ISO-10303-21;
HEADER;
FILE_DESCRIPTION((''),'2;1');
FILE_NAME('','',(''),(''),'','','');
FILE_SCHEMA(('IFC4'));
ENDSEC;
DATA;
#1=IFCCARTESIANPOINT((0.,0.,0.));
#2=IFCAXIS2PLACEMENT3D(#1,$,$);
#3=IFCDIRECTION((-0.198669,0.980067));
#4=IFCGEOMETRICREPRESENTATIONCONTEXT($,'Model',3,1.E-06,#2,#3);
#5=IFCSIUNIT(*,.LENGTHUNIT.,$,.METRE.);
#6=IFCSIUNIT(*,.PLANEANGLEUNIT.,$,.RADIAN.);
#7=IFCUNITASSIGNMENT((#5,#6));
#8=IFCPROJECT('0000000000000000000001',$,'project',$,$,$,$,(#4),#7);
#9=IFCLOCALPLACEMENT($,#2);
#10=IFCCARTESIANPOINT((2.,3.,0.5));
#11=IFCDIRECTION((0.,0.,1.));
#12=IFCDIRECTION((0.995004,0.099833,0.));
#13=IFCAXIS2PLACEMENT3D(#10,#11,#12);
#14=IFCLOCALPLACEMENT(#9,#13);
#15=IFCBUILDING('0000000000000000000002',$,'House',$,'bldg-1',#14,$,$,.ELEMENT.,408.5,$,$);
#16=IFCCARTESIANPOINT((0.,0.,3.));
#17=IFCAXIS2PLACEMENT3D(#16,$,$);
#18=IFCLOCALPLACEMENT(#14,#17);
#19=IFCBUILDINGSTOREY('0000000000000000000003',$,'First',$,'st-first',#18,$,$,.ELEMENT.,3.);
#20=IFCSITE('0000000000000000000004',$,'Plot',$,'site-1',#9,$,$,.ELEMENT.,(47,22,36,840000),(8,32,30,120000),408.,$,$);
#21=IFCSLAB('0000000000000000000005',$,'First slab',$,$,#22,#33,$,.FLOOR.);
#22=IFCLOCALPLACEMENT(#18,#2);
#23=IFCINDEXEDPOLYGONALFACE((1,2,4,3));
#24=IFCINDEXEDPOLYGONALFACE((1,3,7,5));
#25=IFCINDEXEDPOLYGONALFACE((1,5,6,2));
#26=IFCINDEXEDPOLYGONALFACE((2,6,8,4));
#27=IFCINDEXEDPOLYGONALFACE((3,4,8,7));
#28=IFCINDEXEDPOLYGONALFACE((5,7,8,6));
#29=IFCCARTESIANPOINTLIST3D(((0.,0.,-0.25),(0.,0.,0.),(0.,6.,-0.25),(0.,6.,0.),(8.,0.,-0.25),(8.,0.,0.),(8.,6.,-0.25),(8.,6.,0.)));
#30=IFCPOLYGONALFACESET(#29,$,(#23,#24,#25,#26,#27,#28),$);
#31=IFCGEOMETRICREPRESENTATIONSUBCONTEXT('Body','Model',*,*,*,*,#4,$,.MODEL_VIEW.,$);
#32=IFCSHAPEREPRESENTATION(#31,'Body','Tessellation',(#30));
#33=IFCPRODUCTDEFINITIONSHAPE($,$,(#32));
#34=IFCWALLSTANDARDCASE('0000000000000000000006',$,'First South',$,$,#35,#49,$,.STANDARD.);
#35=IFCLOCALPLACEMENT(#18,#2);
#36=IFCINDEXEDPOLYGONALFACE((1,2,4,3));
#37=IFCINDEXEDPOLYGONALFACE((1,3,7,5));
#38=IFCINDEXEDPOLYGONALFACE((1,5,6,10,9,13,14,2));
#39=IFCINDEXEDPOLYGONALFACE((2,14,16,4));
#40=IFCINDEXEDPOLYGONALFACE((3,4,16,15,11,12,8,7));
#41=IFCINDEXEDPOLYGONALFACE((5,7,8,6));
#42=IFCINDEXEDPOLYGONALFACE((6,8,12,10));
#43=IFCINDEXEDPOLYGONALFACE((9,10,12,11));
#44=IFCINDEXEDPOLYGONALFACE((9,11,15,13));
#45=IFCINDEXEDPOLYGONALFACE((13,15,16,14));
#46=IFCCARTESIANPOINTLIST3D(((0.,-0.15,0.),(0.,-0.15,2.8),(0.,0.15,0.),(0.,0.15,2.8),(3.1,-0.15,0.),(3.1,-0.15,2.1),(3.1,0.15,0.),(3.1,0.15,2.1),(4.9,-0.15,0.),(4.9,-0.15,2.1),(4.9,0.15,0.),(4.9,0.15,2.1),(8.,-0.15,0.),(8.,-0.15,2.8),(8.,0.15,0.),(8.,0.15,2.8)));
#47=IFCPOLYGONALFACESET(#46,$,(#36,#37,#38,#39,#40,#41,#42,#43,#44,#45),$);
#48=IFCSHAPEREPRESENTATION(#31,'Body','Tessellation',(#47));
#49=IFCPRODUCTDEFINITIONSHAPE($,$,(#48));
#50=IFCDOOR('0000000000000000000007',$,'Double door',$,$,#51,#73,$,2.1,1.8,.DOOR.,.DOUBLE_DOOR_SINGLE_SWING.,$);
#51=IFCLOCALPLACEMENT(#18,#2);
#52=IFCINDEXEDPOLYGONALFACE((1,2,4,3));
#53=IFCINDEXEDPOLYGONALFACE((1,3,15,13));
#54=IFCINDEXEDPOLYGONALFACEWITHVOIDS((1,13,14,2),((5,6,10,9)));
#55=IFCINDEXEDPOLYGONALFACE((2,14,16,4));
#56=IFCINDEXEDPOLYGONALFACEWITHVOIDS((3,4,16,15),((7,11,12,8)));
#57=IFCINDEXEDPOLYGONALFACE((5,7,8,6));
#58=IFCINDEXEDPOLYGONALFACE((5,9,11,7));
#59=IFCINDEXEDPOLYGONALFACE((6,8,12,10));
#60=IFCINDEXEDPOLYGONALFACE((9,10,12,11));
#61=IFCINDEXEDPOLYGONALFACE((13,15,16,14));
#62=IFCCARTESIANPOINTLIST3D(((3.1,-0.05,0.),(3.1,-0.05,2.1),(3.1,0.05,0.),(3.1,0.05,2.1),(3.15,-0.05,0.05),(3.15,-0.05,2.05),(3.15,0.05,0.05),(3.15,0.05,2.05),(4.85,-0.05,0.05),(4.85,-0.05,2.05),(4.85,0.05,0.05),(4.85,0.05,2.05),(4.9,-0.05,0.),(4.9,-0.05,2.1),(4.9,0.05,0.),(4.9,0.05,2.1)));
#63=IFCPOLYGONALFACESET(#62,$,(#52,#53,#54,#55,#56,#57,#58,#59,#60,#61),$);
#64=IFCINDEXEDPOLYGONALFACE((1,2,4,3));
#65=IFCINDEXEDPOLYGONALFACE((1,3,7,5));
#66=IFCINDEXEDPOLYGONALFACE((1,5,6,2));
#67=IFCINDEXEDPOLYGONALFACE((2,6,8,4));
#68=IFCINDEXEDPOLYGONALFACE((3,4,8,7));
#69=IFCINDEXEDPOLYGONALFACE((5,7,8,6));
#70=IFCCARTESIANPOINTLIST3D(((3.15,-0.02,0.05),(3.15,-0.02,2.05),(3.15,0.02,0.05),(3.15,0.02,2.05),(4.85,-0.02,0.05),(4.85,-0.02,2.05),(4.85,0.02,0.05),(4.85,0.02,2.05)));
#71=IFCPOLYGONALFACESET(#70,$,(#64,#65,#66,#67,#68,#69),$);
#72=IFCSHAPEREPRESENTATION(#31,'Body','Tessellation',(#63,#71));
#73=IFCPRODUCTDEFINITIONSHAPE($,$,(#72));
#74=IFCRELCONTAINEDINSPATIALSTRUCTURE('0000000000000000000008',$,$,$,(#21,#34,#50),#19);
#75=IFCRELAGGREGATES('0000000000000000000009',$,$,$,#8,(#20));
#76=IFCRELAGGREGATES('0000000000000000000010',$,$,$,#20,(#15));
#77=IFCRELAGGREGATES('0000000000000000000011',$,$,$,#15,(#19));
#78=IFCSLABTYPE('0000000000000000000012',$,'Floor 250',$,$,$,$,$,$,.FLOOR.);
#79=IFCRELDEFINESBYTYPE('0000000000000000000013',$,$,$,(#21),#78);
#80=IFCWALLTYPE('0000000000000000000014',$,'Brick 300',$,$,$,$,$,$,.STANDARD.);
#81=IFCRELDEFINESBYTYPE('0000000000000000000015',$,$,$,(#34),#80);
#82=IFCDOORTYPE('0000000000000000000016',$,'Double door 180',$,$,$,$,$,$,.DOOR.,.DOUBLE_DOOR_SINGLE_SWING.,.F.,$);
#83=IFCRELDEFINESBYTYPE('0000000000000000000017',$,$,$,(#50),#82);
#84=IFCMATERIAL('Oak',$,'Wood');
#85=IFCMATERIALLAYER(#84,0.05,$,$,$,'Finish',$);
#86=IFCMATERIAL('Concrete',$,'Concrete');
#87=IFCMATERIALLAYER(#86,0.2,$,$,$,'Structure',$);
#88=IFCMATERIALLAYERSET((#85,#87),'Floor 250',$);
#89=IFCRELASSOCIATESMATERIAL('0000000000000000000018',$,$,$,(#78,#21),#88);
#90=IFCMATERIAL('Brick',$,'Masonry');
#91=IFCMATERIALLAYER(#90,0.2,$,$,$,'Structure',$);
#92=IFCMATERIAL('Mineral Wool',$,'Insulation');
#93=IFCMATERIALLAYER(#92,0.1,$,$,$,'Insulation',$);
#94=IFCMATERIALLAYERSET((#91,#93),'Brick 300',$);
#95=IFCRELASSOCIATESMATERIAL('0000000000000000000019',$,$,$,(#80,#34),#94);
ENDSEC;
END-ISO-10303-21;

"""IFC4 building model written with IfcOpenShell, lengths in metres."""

from ifc_helpers import new_model, si_unit, direction, frame, frame_2d, origin, origin_with_axes, origin_2d, place, context, subcontext, project, spatial, polyline, rectangle, outline, extrude, material, layer, layer_set, layer_usage, type_object, element, fill, save


model = new_model("IFC4")

# Units and contexts
model_context = context("Model", 3, precision=1e-06, world=origin(), true_north=direction((-0.198669, 0.980067)))
body_context = subcontext(model_context, "Body", "Model", "MODEL_VIEW")
ifc_project = project(units=[si_unit("LENGTHUNIT", "METRE"), si_unit("PLANEANGLEUNIT", "RADIAN")], contexts=[model_context])

# Site, building, storey
site_placement = place(None, origin())
site = spatial("IfcSite", under=ifc_project, at=site_placement, Name="Plot", ObjectType="site-1", CompositionType="ELEMENT", RefLatitude=(47, 22, 36, 840000), RefLongitude=(8, 32, 30, 120000), RefElevation=408.0)
building_placement = place(site_placement, frame((2.0, 3.0, 0.5), z_axis=(0.0, 0.0, 1.0), x_axis=(0.995004, 0.099833, 0.0)))
building = spatial("IfcBuilding", under=site, at=building_placement, Name="House", ObjectType="bldg-1", CompositionType="ELEMENT", ElevationOfRefHeight=408.5)
storey_placement = place(building_placement, frame((0.0, 0.0, 3.0)))
storey = spatial("IfcBuildingStorey", under=building, at=storey_placement, Name="First", ObjectType="st-first", CompositionType="ELEMENT", Elevation=3.0)

# Slab
ifc_material_1 = material(Name="Oak", Category="Wood")
ifc_layer_1 = layer(ifc_material_1, 0.05, Category="Finish")
ifc_material_2 = material(Name="Concrete", Category="Concrete")
ifc_layer_2 = layer(ifc_material_2, 0.2, Category="Structure")
ifc_layer_set_1 = layer_set([ifc_layer_1, ifc_layer_2], Name="Floor 250")
ifc_layer_usage_1 = layer_usage(ifc_layer_set_1, "AXIS3", "NEGATIVE", 0.25)
slab_type = type_object("IfcSlabType", Name="Floor 250", PredefinedType="FLOOR", material=ifc_layer_set_1)
slab_placement = place(storey_placement, frame((0.0, 0.0, -0.25)))
element("IfcSlab", 1, at=slab_placement, inside=storey, type_object=slab_type, material=ifc_layer_usage_1, Name="First slab", PredefinedType="FLOOR", context=body_context, shape_type="SweptSolid", body=[
    extrude(outline(polyline([(0.0, 0.0), (8.0, 0.0), (8.0, 6.0), (0.0, 6.0), (0.0, 0.0)])), origin(), (0.0, 0.0, 1.0), 0.25),
])

# Wall, opening, door
ifc_material_3 = material(Name="Brick", Category="Masonry")
ifc_layer_3 = layer(ifc_material_3, 0.2, Category="Structure")
ifc_material_4 = material(Name="Mineral Wool", Category="Insulation")
ifc_layer_4 = layer(ifc_material_4, 0.1, Category="Insulation")
ifc_layer_set_2 = layer_set([ifc_layer_3, ifc_layer_4], Name="Brick 300")
ifc_layer_usage_2 = layer_usage(ifc_layer_set_2, "AXIS2", "NEGATIVE", 0.15)
wall_type = type_object("IfcWallType", Name="Brick 300", PredefinedType="STANDARD", material=ifc_layer_set_2)
wall_placement = place(storey_placement, origin_with_axes())
wall = element("IfcWallStandardCase", 2, at=wall_placement, inside=storey, type_object=wall_type, material=ifc_layer_usage_2, Name="First South", PredefinedType="STANDARD", context=body_context, shape_type="SweptSolid", body=[
    extrude(rectangle(XDim=8.0, YDim=0.3, at=frame_2d((4.0, 0.0))), origin(), (0.0, 0.0, 1.0), 2.8),
])
opening_placement = place(wall_placement, frame((4.0, 0.0, 0.0)))
opening = element("IfcOpeningElement", 3, at=opening_placement, cuts=wall, PredefinedType="OPENING", context=body_context, shape_type="SweptSolid", body=[
    extrude(rectangle(XDim=1.8, YDim=0.3, at=origin_2d()), origin(), (0.0, 0.0, 1.0), 2.1),
])
door_type = type_object("IfcDoorType", Name="Double door 180", OperationType="DOUBLE_DOOR_SINGLE_SWING", ParameterTakesPrecedence=False, PredefinedType="DOOR")
door_placement = place(opening_placement, frame((0.0, 0.0, 0.0), z_axis=(0.0, -1.0, 0.0), x_axis=(1.0, 0.0, 0.0)))
door = element("IfcDoor", 4, at=door_placement, inside=storey, type_object=door_type, Name="Double door", OperationType="DOUBLE_DOOR_SINGLE_SWING", OverallHeight=2.1, OverallWidth=1.8, PredefinedType="DOOR", context=body_context, shape_type="SweptSolid", body=[
    extrude(outline(polyline([(-0.9, 0.0), (0.9, 0.0), (0.9, 2.1), (-0.9, 2.1), (-0.9, 0.0)]), holes=[polyline([(-0.85, 0.05), (0.85, 0.05), (0.85, 2.05), (-0.85, 2.05), (-0.85, 0.05)])]), frame((0.0, 0.0, -0.05)), (0.0, 0.0, 1.0), 0.1),
    extrude(rectangle(XDim=1.7, YDim=2.0, at=frame_2d((0.0, 1.05))), frame((0.0, 0.0, -0.02)), (0.0, 0.0, 1.0), 0.04),
])
fill(opening, door)

save(model, "model.ifc")
